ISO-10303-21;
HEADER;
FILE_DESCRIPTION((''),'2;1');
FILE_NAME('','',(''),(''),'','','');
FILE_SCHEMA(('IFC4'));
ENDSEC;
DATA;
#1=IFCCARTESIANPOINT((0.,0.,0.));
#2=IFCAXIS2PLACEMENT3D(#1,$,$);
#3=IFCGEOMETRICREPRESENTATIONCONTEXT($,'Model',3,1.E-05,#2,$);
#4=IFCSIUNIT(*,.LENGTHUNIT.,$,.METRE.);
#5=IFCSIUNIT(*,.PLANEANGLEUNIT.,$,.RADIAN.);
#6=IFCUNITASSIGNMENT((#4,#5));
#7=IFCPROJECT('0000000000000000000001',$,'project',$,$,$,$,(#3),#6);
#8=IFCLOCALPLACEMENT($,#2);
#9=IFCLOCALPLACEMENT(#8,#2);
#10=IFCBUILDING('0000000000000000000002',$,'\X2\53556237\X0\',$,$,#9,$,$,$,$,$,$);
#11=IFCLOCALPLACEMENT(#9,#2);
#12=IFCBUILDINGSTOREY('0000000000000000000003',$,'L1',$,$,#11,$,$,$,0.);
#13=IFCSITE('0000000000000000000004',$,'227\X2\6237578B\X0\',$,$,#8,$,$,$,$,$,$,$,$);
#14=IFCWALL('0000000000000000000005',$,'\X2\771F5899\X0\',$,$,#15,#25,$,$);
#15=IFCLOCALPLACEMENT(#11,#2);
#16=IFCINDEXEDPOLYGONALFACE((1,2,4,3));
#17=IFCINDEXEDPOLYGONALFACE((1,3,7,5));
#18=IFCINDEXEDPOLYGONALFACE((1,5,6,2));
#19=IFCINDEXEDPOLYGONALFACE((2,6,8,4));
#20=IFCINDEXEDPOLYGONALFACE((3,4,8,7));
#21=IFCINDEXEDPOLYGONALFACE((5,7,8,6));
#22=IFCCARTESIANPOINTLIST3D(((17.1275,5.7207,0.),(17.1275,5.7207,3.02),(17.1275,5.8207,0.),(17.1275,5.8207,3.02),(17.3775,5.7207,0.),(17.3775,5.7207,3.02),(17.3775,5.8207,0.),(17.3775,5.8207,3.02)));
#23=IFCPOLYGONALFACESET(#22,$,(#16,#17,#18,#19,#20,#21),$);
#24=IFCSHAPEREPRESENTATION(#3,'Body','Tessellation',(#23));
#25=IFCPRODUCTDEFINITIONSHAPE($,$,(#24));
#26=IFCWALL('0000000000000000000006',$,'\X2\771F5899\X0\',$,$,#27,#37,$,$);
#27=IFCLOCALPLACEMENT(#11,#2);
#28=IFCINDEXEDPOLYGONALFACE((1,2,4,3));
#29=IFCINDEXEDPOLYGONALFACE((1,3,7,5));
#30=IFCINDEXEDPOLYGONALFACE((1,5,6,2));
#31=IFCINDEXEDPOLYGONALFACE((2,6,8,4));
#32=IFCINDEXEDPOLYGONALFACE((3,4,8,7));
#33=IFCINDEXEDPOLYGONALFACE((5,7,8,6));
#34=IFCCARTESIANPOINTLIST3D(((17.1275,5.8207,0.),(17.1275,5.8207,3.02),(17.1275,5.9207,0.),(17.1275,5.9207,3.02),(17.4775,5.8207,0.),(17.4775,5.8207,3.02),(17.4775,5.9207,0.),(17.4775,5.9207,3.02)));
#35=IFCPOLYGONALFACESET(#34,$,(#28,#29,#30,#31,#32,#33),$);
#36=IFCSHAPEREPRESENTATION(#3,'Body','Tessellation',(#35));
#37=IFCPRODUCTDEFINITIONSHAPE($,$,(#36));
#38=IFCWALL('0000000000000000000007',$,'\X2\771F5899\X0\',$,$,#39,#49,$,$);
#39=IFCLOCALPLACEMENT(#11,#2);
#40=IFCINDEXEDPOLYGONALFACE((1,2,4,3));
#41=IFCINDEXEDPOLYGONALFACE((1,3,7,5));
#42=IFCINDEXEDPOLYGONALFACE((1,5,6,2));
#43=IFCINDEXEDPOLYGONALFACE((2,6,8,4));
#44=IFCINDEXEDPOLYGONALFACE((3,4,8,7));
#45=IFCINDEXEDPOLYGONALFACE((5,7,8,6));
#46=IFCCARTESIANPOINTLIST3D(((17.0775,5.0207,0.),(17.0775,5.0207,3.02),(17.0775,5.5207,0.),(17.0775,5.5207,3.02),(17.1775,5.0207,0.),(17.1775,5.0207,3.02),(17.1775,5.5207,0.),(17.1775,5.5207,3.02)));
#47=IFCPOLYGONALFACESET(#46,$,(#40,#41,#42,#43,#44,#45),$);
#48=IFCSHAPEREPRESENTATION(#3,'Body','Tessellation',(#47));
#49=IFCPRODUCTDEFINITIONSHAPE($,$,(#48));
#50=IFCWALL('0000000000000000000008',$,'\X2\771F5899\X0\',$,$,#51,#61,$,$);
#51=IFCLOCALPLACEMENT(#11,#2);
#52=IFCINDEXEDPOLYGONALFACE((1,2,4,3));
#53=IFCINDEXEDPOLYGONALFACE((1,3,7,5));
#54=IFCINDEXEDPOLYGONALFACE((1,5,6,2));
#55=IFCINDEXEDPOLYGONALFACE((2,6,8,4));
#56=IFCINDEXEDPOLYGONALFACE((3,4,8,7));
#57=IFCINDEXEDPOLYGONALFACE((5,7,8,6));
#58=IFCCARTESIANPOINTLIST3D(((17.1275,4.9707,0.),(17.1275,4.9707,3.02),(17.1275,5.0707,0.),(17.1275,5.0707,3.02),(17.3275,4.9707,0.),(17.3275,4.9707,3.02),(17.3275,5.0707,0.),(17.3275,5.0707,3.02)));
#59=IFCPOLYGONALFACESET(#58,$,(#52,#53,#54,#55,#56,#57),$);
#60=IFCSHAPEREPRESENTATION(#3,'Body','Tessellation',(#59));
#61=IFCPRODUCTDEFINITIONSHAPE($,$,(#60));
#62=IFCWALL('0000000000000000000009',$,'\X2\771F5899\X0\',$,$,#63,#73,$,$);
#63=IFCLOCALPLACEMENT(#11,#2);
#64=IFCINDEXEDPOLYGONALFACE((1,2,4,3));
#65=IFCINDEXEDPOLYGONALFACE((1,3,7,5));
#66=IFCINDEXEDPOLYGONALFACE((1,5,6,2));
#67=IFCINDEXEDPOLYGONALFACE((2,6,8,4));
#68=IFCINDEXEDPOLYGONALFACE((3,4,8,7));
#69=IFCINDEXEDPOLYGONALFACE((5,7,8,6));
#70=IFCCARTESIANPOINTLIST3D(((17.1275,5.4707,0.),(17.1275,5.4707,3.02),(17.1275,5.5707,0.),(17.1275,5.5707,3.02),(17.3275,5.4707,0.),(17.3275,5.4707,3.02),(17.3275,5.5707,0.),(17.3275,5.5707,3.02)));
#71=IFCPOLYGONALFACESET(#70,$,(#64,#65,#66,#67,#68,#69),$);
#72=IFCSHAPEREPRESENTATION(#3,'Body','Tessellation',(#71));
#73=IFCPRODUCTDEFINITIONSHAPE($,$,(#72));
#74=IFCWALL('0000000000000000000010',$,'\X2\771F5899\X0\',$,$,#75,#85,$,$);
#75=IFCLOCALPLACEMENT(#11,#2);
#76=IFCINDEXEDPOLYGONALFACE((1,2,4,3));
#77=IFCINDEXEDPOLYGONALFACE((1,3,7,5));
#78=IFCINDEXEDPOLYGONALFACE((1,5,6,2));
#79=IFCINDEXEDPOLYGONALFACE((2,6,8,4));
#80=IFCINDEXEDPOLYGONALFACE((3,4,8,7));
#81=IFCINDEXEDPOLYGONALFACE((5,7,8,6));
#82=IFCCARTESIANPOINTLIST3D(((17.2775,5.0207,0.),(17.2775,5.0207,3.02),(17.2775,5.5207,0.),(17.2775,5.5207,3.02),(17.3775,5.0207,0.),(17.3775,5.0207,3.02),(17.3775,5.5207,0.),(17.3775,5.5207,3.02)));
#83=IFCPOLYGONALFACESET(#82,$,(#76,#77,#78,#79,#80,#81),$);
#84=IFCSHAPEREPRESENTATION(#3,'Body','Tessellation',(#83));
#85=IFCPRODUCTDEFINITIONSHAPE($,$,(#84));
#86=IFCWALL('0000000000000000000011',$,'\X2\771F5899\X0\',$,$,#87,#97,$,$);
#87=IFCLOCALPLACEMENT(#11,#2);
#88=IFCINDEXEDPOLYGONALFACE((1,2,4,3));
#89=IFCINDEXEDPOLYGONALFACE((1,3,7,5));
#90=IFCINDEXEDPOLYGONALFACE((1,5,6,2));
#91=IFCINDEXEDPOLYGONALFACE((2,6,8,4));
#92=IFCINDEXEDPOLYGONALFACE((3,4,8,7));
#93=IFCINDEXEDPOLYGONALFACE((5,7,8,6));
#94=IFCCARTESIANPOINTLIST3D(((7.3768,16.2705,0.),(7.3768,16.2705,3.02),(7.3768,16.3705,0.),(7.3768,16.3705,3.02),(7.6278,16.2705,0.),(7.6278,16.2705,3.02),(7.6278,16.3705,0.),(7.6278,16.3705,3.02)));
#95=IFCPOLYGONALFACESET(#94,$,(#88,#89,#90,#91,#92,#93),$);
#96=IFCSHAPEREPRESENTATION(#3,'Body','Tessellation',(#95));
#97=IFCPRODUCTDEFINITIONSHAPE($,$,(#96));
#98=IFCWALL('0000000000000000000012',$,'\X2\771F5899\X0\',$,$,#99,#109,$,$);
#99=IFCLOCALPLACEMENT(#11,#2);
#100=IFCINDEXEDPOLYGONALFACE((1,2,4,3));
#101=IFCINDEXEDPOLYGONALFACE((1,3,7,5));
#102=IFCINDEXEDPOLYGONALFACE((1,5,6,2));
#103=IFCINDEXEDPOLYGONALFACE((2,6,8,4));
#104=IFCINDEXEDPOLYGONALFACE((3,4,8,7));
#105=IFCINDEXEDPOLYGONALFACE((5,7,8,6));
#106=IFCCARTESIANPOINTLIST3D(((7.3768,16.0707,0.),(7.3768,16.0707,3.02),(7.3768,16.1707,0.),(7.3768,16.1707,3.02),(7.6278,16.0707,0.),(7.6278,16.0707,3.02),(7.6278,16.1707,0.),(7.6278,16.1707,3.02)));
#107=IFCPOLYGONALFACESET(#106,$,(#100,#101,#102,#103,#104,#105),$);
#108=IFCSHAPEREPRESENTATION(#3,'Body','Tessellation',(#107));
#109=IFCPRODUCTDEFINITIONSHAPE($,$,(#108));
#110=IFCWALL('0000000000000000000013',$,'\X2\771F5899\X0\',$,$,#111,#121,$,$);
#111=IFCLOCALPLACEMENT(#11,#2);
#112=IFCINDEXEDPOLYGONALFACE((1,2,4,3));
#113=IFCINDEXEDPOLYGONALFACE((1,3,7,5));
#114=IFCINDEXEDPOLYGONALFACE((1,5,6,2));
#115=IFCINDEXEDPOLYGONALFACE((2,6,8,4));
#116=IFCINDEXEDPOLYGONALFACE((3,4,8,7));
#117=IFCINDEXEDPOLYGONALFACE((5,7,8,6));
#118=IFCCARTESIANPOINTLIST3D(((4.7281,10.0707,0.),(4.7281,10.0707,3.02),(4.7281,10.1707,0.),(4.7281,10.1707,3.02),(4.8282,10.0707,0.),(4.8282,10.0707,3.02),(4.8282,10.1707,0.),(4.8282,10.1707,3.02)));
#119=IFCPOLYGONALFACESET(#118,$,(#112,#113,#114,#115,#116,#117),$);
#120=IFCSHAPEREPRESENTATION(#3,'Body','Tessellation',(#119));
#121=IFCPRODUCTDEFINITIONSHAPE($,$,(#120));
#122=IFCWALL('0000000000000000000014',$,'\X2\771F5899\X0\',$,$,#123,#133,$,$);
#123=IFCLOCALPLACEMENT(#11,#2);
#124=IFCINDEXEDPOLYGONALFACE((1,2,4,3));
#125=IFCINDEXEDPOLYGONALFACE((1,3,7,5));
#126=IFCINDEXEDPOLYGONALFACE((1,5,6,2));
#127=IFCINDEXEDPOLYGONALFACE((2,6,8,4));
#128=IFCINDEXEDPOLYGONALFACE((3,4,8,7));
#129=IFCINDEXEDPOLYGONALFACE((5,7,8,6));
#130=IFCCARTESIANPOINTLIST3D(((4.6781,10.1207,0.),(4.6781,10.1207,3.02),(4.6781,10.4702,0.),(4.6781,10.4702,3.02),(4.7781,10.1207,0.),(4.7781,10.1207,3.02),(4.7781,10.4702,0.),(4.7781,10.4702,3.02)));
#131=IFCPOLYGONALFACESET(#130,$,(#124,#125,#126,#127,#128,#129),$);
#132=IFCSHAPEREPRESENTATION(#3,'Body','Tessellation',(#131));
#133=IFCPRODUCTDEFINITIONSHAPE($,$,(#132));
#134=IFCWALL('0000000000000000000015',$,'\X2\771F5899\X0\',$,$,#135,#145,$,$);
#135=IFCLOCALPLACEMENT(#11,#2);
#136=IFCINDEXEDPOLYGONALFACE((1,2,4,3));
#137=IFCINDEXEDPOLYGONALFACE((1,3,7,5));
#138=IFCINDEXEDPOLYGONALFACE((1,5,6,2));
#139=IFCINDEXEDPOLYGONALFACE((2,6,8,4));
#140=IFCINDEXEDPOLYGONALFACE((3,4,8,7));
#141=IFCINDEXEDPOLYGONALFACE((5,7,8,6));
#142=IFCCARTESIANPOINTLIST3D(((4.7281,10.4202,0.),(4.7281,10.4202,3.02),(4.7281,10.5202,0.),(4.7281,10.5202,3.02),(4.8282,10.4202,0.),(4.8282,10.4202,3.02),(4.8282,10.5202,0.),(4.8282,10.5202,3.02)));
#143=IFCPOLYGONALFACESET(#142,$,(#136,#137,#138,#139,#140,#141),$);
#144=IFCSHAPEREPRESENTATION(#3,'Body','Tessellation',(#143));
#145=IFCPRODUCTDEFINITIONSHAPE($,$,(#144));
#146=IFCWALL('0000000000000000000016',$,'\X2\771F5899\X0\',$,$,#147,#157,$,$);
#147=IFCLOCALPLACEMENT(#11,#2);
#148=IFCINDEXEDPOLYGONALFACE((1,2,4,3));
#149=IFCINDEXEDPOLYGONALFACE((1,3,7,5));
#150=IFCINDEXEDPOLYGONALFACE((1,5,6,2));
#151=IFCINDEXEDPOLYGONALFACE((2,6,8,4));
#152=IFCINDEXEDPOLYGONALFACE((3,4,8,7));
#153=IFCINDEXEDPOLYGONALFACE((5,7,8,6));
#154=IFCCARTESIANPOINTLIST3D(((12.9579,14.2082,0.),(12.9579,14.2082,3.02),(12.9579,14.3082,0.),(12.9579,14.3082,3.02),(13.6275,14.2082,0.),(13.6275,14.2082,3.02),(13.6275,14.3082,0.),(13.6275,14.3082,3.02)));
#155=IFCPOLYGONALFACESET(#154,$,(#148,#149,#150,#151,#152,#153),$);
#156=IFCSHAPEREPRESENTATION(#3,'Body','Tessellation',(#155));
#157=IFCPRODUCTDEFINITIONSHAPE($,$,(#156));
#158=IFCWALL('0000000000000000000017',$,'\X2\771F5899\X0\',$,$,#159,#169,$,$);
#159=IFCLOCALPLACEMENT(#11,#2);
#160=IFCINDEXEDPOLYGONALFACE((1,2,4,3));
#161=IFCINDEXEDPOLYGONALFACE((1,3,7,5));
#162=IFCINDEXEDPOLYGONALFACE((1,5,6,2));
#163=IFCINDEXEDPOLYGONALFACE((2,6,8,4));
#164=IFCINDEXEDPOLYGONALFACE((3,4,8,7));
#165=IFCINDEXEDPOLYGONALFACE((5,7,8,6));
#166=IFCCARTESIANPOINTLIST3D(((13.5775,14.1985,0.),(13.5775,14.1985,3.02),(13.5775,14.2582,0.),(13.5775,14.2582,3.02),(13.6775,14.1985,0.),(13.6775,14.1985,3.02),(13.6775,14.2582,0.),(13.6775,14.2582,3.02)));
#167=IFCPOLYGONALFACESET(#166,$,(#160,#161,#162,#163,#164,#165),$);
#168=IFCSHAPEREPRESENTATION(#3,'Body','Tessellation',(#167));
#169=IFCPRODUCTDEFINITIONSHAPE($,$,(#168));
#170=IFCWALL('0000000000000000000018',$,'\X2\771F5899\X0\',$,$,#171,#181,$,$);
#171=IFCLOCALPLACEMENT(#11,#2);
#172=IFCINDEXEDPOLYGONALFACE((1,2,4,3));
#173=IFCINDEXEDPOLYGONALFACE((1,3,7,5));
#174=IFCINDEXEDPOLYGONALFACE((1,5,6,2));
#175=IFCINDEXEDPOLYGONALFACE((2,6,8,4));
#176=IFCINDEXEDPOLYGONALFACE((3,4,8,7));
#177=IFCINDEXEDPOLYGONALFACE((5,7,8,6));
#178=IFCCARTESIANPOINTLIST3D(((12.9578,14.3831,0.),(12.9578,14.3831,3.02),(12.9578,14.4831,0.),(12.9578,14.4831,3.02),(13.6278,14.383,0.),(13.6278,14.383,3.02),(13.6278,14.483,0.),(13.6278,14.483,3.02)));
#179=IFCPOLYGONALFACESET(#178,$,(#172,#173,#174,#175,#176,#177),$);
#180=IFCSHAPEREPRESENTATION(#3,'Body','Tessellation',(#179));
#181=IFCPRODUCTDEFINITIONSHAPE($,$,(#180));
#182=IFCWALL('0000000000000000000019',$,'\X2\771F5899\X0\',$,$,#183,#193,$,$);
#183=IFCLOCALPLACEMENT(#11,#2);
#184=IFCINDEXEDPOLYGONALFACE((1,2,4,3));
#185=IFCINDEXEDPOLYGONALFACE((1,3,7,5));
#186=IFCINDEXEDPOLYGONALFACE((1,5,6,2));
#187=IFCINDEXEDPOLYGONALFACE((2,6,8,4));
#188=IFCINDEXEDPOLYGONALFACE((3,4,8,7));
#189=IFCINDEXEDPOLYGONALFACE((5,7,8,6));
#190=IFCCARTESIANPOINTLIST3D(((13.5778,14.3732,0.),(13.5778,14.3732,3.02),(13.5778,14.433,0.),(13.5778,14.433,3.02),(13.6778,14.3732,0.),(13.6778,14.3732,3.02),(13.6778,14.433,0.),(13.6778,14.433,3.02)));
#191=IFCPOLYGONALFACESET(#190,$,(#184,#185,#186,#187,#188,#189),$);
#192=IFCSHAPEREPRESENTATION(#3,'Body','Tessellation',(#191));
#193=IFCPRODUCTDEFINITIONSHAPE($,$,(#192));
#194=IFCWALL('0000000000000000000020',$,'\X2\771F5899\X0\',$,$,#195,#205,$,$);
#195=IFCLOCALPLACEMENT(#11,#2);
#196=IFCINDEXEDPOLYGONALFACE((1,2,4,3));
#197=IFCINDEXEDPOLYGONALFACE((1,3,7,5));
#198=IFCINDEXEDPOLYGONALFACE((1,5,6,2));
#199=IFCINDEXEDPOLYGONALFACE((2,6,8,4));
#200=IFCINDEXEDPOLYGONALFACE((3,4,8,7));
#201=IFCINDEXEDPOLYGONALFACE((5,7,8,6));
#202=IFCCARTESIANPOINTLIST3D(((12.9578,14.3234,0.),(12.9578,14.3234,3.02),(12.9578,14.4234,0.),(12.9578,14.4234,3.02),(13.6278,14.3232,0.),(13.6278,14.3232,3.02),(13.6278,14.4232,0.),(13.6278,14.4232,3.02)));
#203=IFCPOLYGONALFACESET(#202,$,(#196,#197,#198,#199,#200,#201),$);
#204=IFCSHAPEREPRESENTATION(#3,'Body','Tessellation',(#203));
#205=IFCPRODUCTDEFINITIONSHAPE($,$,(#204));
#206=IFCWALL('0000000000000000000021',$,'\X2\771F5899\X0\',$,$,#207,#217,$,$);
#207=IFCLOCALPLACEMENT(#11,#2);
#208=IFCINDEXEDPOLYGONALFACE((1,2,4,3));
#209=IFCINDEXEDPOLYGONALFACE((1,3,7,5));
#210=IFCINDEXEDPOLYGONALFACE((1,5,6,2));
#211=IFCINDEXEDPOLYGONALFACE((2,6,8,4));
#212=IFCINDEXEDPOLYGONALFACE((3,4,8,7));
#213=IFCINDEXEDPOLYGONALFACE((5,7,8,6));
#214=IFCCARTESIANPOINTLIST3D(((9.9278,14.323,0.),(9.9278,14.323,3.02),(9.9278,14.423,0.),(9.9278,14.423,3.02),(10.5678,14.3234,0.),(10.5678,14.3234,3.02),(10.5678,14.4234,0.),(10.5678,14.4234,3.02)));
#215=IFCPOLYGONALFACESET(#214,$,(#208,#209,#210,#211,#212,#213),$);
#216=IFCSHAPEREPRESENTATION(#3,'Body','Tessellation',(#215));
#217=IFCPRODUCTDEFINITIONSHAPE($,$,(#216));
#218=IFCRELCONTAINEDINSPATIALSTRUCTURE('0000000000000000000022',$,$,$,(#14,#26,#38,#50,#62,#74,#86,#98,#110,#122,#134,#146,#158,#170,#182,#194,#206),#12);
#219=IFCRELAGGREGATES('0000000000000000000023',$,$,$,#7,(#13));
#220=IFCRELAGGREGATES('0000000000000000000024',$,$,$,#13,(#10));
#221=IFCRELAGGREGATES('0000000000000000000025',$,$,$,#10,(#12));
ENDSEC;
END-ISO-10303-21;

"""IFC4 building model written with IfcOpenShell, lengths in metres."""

from ifc_helpers import new_model, si_unit, origin, place, context, project, spatial, polyline, outline, extrude, element, save


model = new_model("IFC4")

# Units and contexts
model_context = context("Model", 3, precision=1e-05, world=origin())
ifc_project = project(units=[si_unit("LENGTHUNIT", "METRE"), si_unit("PLANEANGLEUNIT", "RADIAN")], contexts=[model_context])

# Site, building, storey
site_placement = place(None, origin())
site = spatial("IfcSite", under=ifc_project, at=site_placement, Name="227户型")
building_placement = place(site_placement, origin())
building = spatial("IfcBuilding", under=site, at=building_placement, Name="单户")
storey_placement = place(building_placement, origin())
storey = spatial("IfcBuildingStorey", under=building, at=storey_placement, Name="L1", Elevation=0.0)

# Walls
wall_1_placement = place(storey_placement, origin())
element("IfcWall", 1, at=wall_1_placement, inside=storey, Name="真墙", context=model_context, shape_type="SweptSolid", body=[
    extrude(outline(polyline([(17.3775, 5.7207), (17.1275, 5.7207), (17.1275, 5.8207), (17.3775, 5.8207), (17.3775, 5.7207)])), origin(), (0.0, 0.0, 1.0), 3.02),
])
wall_2_placement = place(storey_placement, origin())
element("IfcWall", 2, at=wall_2_placement, inside=storey, Name="真墙", context=model_context, shape_type="SweptSolid", body=[
    extrude(outline(polyline([(17.4775, 5.8207), (17.1275, 5.8207), (17.1275, 5.9207), (17.4775, 5.9207), (17.4775, 5.8207)])), origin(), (0.0, 0.0, 1.0), 3.02),
])
wall_3_placement = place(storey_placement, origin())
element("IfcWall", 3, at=wall_3_placement, inside=storey, Name="真墙", context=model_context, shape_type="SweptSolid", body=[
    extrude(outline(polyline([(17.1775, 5.5207), (17.1775, 5.0207), (17.0775, 5.0207), (17.0775, 5.5207), (17.1775, 5.5207)])), origin(), (0.0, 0.0, 1.0), 3.02),
])
wall_4_placement = place(storey_placement, origin())
element("IfcWall", 4, at=wall_4_placement, inside=storey, Name="真墙", context=model_context, shape_type="SweptSolid", body=[
    extrude(outline(polyline([(17.1275, 5.0707), (17.3275, 5.0707), (17.3275, 4.9707), (17.1275, 4.9707), (17.1275, 5.0707)])), origin(), (0.0, 0.0, 1.0), 3.02),
])
wall_5_placement = place(storey_placement, origin())
element("IfcWall", 5, at=wall_5_placement, inside=storey, Name="真墙", context=model_context, shape_type="SweptSolid", body=[
    extrude(outline(polyline([(17.1275, 5.5707), (17.3275, 5.5707), (17.3275, 5.4707), (17.1275, 5.4707), (17.1275, 5.5707)])), origin(), (0.0, 0.0, 1.0), 3.02),
])
wall_6_placement = place(storey_placement, origin())
element("IfcWall", 6, at=wall_6_placement, inside=storey, Name="真墙", context=model_context, shape_type="SweptSolid", body=[
    extrude(outline(polyline([(17.3775, 5.5207), (17.3775, 5.0207), (17.2775, 5.0207), (17.2775, 5.5207), (17.3775, 5.5207)])), origin(), (0.0, 0.0, 1.0), 3.02),
])
wall_7_placement = place(storey_placement, origin())
element("IfcWall", 7, at=wall_7_placement, inside=storey, Name="真墙", context=model_context, shape_type="SweptSolid", body=[
    extrude(outline(polyline([(7.3768, 16.3705), (7.6278, 16.3705), (7.6278, 16.2705), (7.3768, 16.2705), (7.3768, 16.3705)])), origin(), (0.0, 0.0, 1.0), 3.02),
])

# Walls
wall_8_placement = place(storey_placement, origin())
element("IfcWall", 8, at=wall_8_placement, inside=storey, Name="真墙", context=model_context, shape_type="SweptSolid", body=[
    extrude(outline(polyline([(7.6278, 16.0707), (7.3768, 16.0707), (7.3768, 16.1707), (7.6278, 16.1707), (7.6278, 16.0707)])), origin(), (0.0, 0.0, 1.0), 3.02),
])
wall_9_placement = place(storey_placement, origin())
element("IfcWall", 9, at=wall_9_placement, inside=storey, Name="真墙", context=model_context, shape_type="SweptSolid", body=[
    extrude(outline(polyline([(4.8282, 10.0707), (4.7281, 10.0707), (4.7281, 10.1707), (4.8282, 10.1707), (4.8282, 10.0707)])), origin(), (0.0, 0.0, 1.0), 3.02),
])
wall_10_placement = place(storey_placement, origin())
element("IfcWall", 10, at=wall_10_placement, inside=storey, Name="真墙", context=model_context, shape_type="SweptSolid", body=[
    extrude(outline(polyline([(4.6781, 10.1207), (4.6781, 10.4702), (4.7781, 10.4702), (4.7781, 10.1207), (4.6781, 10.1207)])), origin(), (0.0, 0.0, 1.0), 3.02),
])
wall_11_placement = place(storey_placement, origin())
element("IfcWall", 11, at=wall_11_placement, inside=storey, Name="真墙", context=model_context, shape_type="SweptSolid", body=[
    extrude(outline(polyline([(4.7281, 10.5202), (4.8282, 10.5202), (4.8282, 10.4202), (4.7281, 10.4202), (4.7281, 10.5202)])), origin(), (0.0, 0.0, 1.0), 3.02),
])
wall_12_placement = place(storey_placement, origin())
element("IfcWall", 12, at=wall_12_placement, inside=storey, Name="真墙", context=model_context, shape_type="SweptSolid", body=[
    extrude(outline(polyline([(12.9579, 14.3082), (13.6275, 14.3082), (13.6275, 14.2082), (12.9579, 14.2082), (12.9579, 14.3082)])), origin(), (0.0, 0.0, 1.0), 3.02),
])
wall_13_placement = place(storey_placement, origin())
element("IfcWall", 13, at=wall_13_placement, inside=storey, Name="真墙", context=model_context, shape_type="SweptSolid", body=[
    extrude(outline(polyline([(13.6775, 14.2582), (13.6775, 14.1985), (13.5775, 14.1985), (13.5775, 14.2582), (13.6775, 14.2582)])), origin(), (0.0, 0.0, 1.0), 3.02),
])

# Walls
wall_14_placement = place(storey_placement, origin())
element("IfcWall", 14, at=wall_14_placement, inside=storey, Name="真墙", context=model_context, shape_type="SweptSolid", body=[
    extrude(outline(polyline([(12.9578, 14.4831), (13.6278, 14.483), (13.6278, 14.383), (12.9578, 14.3831), (12.9578, 14.4831)])), origin(), (0.0, 0.0, 1.0), 3.02),
])
wall_15_placement = place(storey_placement, origin())
element("IfcWall", 15, at=wall_15_placement, inside=storey, Name="真墙", context=model_context, shape_type="SweptSolid", body=[
    extrude(outline(polyline([(13.6778, 14.433), (13.6778, 14.3732), (13.5778, 14.3732), (13.5778, 14.433), (13.6778, 14.433)])), origin(), (0.0, 0.0, 1.0), 3.02),
])
wall_16_placement = place(storey_placement, origin())
element("IfcWall", 16, at=wall_16_placement, inside=storey, Name="真墙", context=model_context, shape_type="SweptSolid", body=[
    extrude(outline(polyline([(13.6278, 14.3232), (12.9578, 14.3234), (12.9578, 14.4234), (13.6278, 14.4232), (13.6278, 14.3232)])), origin(), (0.0, 0.0, 1.0), 3.02),
])
wall_17_placement = place(storey_placement, origin())
element("IfcWall", 17, at=wall_17_placement, inside=storey, Name="真墙", context=model_context, shape_type="SweptSolid", body=[
    extrude(outline(polyline([(10.5678, 14.3234), (9.9278, 14.323), (9.9278, 14.423), (10.5678, 14.4234), (10.5678, 14.3234)])), origin(), (0.0, 0.0, 1.0), 3.02),
])

save(model, "model.ifc")
